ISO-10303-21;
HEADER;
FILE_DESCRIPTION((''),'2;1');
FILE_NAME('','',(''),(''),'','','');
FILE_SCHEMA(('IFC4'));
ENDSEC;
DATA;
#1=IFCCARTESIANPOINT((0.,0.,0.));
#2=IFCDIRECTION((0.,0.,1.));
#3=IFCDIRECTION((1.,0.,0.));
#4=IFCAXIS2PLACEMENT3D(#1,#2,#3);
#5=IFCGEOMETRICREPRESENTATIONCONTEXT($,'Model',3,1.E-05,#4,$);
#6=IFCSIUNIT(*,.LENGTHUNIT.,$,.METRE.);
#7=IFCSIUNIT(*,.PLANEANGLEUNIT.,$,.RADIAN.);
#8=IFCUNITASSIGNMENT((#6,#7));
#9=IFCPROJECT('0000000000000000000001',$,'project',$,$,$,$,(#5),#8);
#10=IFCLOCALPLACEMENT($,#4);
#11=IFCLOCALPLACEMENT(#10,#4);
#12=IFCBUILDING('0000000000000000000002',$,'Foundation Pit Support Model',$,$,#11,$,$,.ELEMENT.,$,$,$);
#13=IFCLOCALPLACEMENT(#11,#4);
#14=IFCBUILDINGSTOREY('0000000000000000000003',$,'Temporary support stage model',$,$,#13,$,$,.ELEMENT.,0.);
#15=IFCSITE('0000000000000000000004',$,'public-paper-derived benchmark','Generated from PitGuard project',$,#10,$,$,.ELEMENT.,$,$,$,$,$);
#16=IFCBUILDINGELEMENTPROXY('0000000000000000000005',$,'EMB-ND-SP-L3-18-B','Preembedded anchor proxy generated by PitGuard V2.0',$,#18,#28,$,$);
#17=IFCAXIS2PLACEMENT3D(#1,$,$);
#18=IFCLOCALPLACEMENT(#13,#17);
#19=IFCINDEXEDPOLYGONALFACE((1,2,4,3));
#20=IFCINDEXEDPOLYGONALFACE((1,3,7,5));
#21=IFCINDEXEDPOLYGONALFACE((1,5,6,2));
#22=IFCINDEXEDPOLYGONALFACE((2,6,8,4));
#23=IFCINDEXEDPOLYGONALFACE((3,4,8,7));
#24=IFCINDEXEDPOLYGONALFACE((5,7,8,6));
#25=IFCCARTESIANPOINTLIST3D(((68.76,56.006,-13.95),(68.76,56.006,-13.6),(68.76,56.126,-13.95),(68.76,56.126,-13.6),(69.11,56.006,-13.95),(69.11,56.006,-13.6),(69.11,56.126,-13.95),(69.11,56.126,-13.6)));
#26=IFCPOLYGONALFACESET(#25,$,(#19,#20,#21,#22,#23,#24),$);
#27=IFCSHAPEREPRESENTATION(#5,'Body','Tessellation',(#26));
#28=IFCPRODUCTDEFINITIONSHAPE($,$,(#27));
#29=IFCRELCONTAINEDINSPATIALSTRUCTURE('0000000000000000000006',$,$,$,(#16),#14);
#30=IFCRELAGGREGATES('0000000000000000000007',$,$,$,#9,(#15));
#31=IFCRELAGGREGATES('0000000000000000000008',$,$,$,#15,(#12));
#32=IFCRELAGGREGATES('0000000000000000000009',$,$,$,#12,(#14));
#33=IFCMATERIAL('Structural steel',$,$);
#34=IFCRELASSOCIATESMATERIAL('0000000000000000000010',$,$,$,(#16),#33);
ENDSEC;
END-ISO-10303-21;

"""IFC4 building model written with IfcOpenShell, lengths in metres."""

from ifc_helpers import new_model, si_unit, frame, origin_with_axes, origin_2d, place, context, project, spatial, rectangle, extrude, material, element, save


model = new_model("IFC4")

# Units and contexts
model_context = context("Model", 3, precision=1e-05, world=origin_with_axes())
ifc_project = project(units=[si_unit("LENGTHUNIT", "METRE"), si_unit("PLANEANGLEUNIT", "RADIAN")], contexts=[model_context])

# Site, building, storey
site_placement = place(None, origin_with_axes())
site = spatial("IfcSite", under=ifc_project, at=site_placement, Name="public-paper-derived benchmark", Description="Generated from PitGuard project", CompositionType="ELEMENT")
building_placement = place(site_placement, origin_with_axes())
building = spatial("IfcBuilding", under=site, at=building_placement, Name="Foundation Pit Support Model", CompositionType="ELEMENT")
storey_placement = place(building_placement, origin_with_axes())
storey = spatial("IfcBuildingStorey", under=building, at=storey_placement, Name="Temporary support stage model", CompositionType="ELEMENT", Elevation=0.0)

# Shared definitions
ifc_material_1 = material(Name="Structural steel")

# Building element proxy
proxy_1_placement = place(storey_placement, frame((68.935, 56.066, -13.95), z_axis=(0.0, 0.0, 1.0), x_axis=(1.0, 0.0, 0.0)))
element("IfcBuildingElementProxy", 1, at=proxy_1_placement, inside=storey, material=ifc_material_1, Name="EMB-ND-SP-L3-18-B", Description="Preembedded anchor proxy generated by PitGuard V2.0", context=model_context, shape_type="SweptSolid", body=[
    extrude(rectangle(XDim=0.35, YDim=0.12, at=origin_2d()), origin_with_axes(), (0.0, 0.0, 1.0), 0.35),
])

save(model, "model.ifc")
